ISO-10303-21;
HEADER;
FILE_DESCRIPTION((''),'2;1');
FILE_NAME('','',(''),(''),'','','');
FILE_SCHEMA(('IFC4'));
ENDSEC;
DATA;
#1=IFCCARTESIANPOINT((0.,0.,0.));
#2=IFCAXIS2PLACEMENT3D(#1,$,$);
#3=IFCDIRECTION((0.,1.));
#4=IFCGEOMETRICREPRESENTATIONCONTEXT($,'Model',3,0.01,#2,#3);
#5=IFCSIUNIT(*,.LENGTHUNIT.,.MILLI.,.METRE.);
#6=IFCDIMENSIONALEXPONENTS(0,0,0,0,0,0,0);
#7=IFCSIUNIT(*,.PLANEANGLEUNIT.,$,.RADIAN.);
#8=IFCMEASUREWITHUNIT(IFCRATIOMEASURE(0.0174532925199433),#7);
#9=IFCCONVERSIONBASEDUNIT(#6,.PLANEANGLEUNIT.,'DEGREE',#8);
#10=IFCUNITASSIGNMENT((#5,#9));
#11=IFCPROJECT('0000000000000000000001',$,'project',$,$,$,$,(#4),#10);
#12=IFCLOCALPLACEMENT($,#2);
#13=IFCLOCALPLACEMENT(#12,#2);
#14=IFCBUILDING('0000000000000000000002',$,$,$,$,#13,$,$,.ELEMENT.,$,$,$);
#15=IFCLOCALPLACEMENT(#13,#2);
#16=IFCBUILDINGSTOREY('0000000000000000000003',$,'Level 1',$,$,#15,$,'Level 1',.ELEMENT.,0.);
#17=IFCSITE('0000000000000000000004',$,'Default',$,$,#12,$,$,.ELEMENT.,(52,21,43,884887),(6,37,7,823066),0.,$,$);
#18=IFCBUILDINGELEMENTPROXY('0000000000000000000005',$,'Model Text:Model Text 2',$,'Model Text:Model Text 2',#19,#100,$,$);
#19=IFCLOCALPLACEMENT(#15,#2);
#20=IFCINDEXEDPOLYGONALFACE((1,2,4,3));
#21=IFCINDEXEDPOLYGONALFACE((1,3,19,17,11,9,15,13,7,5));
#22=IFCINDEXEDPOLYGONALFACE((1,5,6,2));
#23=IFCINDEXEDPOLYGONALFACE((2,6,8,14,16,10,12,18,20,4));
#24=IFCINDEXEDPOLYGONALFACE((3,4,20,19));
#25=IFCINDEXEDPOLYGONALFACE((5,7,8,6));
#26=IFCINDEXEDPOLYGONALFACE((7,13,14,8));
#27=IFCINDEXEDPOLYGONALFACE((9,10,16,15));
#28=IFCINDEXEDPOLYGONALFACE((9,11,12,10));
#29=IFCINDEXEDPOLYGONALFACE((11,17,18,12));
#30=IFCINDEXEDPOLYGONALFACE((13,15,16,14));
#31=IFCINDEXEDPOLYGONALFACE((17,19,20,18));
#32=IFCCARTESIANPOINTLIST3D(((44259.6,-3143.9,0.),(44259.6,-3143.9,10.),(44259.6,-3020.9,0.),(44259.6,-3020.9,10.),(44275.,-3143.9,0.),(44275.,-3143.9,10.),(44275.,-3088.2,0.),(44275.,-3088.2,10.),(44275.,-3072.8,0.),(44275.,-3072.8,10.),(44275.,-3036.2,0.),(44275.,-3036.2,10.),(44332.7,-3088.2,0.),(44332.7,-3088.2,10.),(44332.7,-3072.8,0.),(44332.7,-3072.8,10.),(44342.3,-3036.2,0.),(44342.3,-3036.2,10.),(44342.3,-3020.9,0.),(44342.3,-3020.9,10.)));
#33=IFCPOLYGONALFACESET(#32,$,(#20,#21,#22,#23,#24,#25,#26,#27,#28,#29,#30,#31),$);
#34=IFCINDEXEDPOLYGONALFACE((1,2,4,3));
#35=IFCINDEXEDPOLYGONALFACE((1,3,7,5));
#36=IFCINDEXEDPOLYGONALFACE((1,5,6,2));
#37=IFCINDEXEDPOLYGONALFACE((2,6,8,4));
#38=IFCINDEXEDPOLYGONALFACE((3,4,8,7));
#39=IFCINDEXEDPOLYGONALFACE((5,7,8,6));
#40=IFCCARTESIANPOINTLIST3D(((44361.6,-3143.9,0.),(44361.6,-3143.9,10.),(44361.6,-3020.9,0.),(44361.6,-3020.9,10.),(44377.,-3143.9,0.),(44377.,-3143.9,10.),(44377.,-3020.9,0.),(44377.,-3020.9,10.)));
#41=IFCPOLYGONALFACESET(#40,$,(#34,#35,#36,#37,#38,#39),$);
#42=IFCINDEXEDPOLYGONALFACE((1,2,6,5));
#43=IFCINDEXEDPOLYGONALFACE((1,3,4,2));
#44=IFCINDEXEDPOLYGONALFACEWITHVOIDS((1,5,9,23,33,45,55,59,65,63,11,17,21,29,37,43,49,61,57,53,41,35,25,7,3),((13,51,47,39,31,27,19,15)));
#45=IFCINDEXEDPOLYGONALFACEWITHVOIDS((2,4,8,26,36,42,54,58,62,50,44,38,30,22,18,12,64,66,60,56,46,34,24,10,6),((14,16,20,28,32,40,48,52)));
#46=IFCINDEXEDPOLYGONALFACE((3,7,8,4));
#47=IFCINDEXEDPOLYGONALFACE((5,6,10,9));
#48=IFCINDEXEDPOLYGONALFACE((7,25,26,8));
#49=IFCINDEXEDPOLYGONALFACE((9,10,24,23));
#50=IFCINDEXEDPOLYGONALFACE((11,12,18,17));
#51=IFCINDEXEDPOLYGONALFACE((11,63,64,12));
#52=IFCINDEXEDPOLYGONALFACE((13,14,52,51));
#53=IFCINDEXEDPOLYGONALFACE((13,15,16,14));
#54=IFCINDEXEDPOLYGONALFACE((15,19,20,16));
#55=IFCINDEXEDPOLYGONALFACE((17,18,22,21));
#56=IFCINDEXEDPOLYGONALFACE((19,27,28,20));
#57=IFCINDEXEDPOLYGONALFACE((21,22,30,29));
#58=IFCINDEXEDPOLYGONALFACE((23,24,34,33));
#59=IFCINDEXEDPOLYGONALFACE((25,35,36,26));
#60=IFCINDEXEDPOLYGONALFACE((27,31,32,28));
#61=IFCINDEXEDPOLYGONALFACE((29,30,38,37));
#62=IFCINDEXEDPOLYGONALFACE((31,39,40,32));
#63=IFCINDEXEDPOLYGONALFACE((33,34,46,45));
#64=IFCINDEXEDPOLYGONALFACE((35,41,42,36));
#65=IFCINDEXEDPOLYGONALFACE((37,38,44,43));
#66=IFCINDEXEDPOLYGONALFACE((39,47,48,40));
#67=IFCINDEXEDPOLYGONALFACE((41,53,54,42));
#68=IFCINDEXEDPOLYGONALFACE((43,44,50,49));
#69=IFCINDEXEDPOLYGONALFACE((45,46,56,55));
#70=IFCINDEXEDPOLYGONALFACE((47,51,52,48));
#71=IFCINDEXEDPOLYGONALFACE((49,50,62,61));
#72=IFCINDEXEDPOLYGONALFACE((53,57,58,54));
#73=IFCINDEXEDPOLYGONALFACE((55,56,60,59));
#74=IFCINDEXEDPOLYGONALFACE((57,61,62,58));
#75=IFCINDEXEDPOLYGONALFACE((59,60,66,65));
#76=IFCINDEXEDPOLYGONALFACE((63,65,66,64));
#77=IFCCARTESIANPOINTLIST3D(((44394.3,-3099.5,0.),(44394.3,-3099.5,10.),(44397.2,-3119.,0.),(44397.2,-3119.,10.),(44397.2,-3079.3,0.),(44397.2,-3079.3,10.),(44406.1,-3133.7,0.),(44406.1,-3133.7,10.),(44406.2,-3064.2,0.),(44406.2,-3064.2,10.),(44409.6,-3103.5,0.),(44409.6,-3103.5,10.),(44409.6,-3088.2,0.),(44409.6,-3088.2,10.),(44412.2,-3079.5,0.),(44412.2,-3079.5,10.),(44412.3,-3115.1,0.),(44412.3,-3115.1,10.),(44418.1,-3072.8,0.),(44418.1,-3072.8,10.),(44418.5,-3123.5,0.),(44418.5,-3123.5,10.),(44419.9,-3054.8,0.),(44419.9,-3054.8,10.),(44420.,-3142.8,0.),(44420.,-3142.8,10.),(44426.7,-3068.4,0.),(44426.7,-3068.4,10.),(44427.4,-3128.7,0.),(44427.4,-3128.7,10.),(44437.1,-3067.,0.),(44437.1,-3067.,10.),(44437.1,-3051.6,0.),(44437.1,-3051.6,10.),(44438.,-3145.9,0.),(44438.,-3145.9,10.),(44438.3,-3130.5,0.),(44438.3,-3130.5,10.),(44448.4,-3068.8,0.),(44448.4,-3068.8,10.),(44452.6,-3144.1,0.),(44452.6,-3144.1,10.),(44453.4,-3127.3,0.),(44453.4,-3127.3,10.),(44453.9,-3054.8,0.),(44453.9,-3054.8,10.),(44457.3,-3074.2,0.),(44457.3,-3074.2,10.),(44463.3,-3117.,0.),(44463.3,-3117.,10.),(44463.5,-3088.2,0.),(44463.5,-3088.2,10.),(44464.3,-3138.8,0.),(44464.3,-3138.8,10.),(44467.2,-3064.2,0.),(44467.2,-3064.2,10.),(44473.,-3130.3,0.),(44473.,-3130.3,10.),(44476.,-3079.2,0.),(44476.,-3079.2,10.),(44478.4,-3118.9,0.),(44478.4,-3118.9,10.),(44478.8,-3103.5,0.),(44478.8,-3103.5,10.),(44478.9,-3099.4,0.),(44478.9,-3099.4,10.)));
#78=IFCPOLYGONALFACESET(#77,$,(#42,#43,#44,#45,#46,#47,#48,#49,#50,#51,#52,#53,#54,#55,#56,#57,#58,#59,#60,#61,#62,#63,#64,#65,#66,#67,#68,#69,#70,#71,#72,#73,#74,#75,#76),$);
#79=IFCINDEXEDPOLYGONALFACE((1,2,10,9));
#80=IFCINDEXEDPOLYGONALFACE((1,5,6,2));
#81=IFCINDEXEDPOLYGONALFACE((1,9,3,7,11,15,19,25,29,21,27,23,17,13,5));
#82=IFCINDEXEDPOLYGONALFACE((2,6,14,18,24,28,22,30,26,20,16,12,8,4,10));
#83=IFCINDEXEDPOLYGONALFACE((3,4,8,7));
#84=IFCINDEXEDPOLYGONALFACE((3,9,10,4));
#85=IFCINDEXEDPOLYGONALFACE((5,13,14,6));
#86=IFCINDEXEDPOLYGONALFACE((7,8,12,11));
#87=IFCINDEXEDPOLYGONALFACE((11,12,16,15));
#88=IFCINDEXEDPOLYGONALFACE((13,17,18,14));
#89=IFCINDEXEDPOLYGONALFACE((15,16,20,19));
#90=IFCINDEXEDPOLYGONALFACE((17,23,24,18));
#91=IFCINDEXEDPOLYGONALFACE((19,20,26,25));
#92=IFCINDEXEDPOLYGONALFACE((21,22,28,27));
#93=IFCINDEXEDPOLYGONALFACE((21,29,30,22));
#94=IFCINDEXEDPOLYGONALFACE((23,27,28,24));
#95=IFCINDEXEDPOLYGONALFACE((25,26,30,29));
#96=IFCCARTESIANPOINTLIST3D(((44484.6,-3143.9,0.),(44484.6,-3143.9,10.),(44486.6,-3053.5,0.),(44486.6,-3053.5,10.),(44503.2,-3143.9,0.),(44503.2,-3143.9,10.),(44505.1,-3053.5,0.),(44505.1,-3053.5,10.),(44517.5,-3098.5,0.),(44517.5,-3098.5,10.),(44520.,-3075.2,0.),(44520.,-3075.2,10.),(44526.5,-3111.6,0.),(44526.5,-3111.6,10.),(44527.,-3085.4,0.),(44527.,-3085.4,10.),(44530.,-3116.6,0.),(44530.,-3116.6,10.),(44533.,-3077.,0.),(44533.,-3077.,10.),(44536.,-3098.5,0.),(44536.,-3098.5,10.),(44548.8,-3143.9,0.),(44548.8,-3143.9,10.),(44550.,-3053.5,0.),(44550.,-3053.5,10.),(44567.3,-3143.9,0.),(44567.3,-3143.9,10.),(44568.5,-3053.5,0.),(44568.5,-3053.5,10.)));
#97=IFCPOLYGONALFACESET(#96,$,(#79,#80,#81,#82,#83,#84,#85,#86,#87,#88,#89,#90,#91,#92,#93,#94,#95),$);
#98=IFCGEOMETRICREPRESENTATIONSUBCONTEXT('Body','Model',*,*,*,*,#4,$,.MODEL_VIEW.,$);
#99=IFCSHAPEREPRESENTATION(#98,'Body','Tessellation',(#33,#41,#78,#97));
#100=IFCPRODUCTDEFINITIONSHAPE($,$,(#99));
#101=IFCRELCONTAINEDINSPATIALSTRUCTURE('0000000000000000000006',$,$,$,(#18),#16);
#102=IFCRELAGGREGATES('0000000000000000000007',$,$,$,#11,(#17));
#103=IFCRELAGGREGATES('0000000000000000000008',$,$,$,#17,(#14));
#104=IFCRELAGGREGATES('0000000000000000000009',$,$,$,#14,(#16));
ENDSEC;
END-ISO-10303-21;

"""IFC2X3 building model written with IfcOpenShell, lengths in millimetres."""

from ifc_helpers import new_model, entity, si_unit, converted_unit, direction, frame, origin, origin_2d_with_axis, place, context, subcontext, project, spatial, polyline, rectangle, outline, extrude, element, save


model = new_model("IFC2X3")

# Units and contexts
model_context = context("Model", 3, precision=0.01, world=origin(), true_north=direction((0.0, 1.0)))
body_context = subcontext(model_context, "Body", "Model", "MODEL_VIEW")
ifc_project = project(units=[si_unit("LENGTHUNIT", "METRE", prefix="MILLI"), converted_unit("PLANEANGLEUNIT", "DEGREE", entity("IfcRatioMeasure", 0.0174532925199433), si_unit("PLANEANGLEUNIT", "RADIAN"), dimensions=[0, 0, 0, 0, 0, 0, 0])], contexts=[model_context])

# Site, building, storey
site_placement = place(None, origin())
site = spatial("IfcSite", under=ifc_project, at=site_placement, Name="Default", CompositionType="ELEMENT", RefLatitude=(52, 21, 43, 884887), RefLongitude=(6, 37, 7, 823066), RefElevation=0.0)
building_placement = place(site_placement, origin())
building = spatial("IfcBuilding", under=site, at=building_placement, CompositionType="ELEMENT")
storey_placement = place(building_placement, origin())
storey = spatial("IfcBuildingStorey", under=building, at=storey_placement, Name="Level 1", LongName="Level 1", CompositionType="ELEMENT", Elevation=0.0)

# Building element proxy
proxy_1_placement = place(storey_placement, origin())
element("IfcBuildingElementProxy", 1, at=proxy_1_placement, inside=storey, Name="Model Text:Model Text 2", ObjectType="Model Text:Model Text 2", context=body_context, shape_type="SweptSolid", body=[
    extrude(outline(polyline([(-37.3, -71.5), (-21.9, -71.5), (-21.9, -15.8), (35.8, -15.8), (35.8, -0.4), (-21.9, -0.4), (-21.9, 36.2), (45.4, 36.2), (45.4, 51.5), (-37.3, 51.5), (-37.3, -71.5)])), frame((44297.0, -3072.4, 0.0)), (0.0, 0.0, 1.0), 10.0),
    extrude(rectangle(XDim=15.4, YDim=123.1, at=origin_2d_with_axis()), frame((44369.3, -3082.4, 0.0)), (0.0, 0.0, 1.0), 10.0),
    extrude(outline(polyline([(-9.9, -25.0), (-19.0, -37.1), (-7.1, -41.1), (5.1, -40.8), (17.0, -36.1), (28.4, -26.8), (38.8, -11.8), (41.9, 4.6), (37.5, 21.1), (25.5, 36.8), (8.9, 48.7), (-8.2, 52.8), (-24.5, 49.5), (-38.7, 39.3), (-48.1, 25.1), (-50.6, 9.0), (-45.9, -7.8), (-33.4, -23.9), (-30.4, -26.7), (17.7, 23.0), (24.1, 13.0), (25.9, 2.7), (23.5, -7.3), (17.1, -16.4), (4.3, -25.0), (-9.9, -25.0)]), holes=[polyline([(6.7, 33.7), (-30.8, -5.0), (-36.5, 9.1), (-34.2, 19.3), (-27.6, 28.7), (-19.4, 35.1), (-10.3, 38.3), (-1.3, 37.9), (6.7, 33.7)])]), frame((44438.5, -3106.8, 0.0), z_axis=(0.0, 0.0, -1.0), x_axis=(-0.695421, -0.718602, 0.0)), (0.0, 0.0, -1.0), 10.0),
    extrude(outline(polyline([(-42.3, -47.1), (-23.8, -47.1), (-0.4, -14.8), (3.0, -19.8), (21.9, -47.1), (40.4, -47.1), (9.1, -1.6), (41.6, 43.3), (23.1, 43.3), (6.1, 19.8), (0.0, 11.5), (-6.9, 21.7), (-21.9, 43.3), (-40.4, 43.3), (-9.4, -1.6), (-42.3, -47.1)])), frame((44527.0, -3096.9, 0.0)), (0.0, 0.0, 1.0), 10.0),
])

save(model, "model.ifc")
